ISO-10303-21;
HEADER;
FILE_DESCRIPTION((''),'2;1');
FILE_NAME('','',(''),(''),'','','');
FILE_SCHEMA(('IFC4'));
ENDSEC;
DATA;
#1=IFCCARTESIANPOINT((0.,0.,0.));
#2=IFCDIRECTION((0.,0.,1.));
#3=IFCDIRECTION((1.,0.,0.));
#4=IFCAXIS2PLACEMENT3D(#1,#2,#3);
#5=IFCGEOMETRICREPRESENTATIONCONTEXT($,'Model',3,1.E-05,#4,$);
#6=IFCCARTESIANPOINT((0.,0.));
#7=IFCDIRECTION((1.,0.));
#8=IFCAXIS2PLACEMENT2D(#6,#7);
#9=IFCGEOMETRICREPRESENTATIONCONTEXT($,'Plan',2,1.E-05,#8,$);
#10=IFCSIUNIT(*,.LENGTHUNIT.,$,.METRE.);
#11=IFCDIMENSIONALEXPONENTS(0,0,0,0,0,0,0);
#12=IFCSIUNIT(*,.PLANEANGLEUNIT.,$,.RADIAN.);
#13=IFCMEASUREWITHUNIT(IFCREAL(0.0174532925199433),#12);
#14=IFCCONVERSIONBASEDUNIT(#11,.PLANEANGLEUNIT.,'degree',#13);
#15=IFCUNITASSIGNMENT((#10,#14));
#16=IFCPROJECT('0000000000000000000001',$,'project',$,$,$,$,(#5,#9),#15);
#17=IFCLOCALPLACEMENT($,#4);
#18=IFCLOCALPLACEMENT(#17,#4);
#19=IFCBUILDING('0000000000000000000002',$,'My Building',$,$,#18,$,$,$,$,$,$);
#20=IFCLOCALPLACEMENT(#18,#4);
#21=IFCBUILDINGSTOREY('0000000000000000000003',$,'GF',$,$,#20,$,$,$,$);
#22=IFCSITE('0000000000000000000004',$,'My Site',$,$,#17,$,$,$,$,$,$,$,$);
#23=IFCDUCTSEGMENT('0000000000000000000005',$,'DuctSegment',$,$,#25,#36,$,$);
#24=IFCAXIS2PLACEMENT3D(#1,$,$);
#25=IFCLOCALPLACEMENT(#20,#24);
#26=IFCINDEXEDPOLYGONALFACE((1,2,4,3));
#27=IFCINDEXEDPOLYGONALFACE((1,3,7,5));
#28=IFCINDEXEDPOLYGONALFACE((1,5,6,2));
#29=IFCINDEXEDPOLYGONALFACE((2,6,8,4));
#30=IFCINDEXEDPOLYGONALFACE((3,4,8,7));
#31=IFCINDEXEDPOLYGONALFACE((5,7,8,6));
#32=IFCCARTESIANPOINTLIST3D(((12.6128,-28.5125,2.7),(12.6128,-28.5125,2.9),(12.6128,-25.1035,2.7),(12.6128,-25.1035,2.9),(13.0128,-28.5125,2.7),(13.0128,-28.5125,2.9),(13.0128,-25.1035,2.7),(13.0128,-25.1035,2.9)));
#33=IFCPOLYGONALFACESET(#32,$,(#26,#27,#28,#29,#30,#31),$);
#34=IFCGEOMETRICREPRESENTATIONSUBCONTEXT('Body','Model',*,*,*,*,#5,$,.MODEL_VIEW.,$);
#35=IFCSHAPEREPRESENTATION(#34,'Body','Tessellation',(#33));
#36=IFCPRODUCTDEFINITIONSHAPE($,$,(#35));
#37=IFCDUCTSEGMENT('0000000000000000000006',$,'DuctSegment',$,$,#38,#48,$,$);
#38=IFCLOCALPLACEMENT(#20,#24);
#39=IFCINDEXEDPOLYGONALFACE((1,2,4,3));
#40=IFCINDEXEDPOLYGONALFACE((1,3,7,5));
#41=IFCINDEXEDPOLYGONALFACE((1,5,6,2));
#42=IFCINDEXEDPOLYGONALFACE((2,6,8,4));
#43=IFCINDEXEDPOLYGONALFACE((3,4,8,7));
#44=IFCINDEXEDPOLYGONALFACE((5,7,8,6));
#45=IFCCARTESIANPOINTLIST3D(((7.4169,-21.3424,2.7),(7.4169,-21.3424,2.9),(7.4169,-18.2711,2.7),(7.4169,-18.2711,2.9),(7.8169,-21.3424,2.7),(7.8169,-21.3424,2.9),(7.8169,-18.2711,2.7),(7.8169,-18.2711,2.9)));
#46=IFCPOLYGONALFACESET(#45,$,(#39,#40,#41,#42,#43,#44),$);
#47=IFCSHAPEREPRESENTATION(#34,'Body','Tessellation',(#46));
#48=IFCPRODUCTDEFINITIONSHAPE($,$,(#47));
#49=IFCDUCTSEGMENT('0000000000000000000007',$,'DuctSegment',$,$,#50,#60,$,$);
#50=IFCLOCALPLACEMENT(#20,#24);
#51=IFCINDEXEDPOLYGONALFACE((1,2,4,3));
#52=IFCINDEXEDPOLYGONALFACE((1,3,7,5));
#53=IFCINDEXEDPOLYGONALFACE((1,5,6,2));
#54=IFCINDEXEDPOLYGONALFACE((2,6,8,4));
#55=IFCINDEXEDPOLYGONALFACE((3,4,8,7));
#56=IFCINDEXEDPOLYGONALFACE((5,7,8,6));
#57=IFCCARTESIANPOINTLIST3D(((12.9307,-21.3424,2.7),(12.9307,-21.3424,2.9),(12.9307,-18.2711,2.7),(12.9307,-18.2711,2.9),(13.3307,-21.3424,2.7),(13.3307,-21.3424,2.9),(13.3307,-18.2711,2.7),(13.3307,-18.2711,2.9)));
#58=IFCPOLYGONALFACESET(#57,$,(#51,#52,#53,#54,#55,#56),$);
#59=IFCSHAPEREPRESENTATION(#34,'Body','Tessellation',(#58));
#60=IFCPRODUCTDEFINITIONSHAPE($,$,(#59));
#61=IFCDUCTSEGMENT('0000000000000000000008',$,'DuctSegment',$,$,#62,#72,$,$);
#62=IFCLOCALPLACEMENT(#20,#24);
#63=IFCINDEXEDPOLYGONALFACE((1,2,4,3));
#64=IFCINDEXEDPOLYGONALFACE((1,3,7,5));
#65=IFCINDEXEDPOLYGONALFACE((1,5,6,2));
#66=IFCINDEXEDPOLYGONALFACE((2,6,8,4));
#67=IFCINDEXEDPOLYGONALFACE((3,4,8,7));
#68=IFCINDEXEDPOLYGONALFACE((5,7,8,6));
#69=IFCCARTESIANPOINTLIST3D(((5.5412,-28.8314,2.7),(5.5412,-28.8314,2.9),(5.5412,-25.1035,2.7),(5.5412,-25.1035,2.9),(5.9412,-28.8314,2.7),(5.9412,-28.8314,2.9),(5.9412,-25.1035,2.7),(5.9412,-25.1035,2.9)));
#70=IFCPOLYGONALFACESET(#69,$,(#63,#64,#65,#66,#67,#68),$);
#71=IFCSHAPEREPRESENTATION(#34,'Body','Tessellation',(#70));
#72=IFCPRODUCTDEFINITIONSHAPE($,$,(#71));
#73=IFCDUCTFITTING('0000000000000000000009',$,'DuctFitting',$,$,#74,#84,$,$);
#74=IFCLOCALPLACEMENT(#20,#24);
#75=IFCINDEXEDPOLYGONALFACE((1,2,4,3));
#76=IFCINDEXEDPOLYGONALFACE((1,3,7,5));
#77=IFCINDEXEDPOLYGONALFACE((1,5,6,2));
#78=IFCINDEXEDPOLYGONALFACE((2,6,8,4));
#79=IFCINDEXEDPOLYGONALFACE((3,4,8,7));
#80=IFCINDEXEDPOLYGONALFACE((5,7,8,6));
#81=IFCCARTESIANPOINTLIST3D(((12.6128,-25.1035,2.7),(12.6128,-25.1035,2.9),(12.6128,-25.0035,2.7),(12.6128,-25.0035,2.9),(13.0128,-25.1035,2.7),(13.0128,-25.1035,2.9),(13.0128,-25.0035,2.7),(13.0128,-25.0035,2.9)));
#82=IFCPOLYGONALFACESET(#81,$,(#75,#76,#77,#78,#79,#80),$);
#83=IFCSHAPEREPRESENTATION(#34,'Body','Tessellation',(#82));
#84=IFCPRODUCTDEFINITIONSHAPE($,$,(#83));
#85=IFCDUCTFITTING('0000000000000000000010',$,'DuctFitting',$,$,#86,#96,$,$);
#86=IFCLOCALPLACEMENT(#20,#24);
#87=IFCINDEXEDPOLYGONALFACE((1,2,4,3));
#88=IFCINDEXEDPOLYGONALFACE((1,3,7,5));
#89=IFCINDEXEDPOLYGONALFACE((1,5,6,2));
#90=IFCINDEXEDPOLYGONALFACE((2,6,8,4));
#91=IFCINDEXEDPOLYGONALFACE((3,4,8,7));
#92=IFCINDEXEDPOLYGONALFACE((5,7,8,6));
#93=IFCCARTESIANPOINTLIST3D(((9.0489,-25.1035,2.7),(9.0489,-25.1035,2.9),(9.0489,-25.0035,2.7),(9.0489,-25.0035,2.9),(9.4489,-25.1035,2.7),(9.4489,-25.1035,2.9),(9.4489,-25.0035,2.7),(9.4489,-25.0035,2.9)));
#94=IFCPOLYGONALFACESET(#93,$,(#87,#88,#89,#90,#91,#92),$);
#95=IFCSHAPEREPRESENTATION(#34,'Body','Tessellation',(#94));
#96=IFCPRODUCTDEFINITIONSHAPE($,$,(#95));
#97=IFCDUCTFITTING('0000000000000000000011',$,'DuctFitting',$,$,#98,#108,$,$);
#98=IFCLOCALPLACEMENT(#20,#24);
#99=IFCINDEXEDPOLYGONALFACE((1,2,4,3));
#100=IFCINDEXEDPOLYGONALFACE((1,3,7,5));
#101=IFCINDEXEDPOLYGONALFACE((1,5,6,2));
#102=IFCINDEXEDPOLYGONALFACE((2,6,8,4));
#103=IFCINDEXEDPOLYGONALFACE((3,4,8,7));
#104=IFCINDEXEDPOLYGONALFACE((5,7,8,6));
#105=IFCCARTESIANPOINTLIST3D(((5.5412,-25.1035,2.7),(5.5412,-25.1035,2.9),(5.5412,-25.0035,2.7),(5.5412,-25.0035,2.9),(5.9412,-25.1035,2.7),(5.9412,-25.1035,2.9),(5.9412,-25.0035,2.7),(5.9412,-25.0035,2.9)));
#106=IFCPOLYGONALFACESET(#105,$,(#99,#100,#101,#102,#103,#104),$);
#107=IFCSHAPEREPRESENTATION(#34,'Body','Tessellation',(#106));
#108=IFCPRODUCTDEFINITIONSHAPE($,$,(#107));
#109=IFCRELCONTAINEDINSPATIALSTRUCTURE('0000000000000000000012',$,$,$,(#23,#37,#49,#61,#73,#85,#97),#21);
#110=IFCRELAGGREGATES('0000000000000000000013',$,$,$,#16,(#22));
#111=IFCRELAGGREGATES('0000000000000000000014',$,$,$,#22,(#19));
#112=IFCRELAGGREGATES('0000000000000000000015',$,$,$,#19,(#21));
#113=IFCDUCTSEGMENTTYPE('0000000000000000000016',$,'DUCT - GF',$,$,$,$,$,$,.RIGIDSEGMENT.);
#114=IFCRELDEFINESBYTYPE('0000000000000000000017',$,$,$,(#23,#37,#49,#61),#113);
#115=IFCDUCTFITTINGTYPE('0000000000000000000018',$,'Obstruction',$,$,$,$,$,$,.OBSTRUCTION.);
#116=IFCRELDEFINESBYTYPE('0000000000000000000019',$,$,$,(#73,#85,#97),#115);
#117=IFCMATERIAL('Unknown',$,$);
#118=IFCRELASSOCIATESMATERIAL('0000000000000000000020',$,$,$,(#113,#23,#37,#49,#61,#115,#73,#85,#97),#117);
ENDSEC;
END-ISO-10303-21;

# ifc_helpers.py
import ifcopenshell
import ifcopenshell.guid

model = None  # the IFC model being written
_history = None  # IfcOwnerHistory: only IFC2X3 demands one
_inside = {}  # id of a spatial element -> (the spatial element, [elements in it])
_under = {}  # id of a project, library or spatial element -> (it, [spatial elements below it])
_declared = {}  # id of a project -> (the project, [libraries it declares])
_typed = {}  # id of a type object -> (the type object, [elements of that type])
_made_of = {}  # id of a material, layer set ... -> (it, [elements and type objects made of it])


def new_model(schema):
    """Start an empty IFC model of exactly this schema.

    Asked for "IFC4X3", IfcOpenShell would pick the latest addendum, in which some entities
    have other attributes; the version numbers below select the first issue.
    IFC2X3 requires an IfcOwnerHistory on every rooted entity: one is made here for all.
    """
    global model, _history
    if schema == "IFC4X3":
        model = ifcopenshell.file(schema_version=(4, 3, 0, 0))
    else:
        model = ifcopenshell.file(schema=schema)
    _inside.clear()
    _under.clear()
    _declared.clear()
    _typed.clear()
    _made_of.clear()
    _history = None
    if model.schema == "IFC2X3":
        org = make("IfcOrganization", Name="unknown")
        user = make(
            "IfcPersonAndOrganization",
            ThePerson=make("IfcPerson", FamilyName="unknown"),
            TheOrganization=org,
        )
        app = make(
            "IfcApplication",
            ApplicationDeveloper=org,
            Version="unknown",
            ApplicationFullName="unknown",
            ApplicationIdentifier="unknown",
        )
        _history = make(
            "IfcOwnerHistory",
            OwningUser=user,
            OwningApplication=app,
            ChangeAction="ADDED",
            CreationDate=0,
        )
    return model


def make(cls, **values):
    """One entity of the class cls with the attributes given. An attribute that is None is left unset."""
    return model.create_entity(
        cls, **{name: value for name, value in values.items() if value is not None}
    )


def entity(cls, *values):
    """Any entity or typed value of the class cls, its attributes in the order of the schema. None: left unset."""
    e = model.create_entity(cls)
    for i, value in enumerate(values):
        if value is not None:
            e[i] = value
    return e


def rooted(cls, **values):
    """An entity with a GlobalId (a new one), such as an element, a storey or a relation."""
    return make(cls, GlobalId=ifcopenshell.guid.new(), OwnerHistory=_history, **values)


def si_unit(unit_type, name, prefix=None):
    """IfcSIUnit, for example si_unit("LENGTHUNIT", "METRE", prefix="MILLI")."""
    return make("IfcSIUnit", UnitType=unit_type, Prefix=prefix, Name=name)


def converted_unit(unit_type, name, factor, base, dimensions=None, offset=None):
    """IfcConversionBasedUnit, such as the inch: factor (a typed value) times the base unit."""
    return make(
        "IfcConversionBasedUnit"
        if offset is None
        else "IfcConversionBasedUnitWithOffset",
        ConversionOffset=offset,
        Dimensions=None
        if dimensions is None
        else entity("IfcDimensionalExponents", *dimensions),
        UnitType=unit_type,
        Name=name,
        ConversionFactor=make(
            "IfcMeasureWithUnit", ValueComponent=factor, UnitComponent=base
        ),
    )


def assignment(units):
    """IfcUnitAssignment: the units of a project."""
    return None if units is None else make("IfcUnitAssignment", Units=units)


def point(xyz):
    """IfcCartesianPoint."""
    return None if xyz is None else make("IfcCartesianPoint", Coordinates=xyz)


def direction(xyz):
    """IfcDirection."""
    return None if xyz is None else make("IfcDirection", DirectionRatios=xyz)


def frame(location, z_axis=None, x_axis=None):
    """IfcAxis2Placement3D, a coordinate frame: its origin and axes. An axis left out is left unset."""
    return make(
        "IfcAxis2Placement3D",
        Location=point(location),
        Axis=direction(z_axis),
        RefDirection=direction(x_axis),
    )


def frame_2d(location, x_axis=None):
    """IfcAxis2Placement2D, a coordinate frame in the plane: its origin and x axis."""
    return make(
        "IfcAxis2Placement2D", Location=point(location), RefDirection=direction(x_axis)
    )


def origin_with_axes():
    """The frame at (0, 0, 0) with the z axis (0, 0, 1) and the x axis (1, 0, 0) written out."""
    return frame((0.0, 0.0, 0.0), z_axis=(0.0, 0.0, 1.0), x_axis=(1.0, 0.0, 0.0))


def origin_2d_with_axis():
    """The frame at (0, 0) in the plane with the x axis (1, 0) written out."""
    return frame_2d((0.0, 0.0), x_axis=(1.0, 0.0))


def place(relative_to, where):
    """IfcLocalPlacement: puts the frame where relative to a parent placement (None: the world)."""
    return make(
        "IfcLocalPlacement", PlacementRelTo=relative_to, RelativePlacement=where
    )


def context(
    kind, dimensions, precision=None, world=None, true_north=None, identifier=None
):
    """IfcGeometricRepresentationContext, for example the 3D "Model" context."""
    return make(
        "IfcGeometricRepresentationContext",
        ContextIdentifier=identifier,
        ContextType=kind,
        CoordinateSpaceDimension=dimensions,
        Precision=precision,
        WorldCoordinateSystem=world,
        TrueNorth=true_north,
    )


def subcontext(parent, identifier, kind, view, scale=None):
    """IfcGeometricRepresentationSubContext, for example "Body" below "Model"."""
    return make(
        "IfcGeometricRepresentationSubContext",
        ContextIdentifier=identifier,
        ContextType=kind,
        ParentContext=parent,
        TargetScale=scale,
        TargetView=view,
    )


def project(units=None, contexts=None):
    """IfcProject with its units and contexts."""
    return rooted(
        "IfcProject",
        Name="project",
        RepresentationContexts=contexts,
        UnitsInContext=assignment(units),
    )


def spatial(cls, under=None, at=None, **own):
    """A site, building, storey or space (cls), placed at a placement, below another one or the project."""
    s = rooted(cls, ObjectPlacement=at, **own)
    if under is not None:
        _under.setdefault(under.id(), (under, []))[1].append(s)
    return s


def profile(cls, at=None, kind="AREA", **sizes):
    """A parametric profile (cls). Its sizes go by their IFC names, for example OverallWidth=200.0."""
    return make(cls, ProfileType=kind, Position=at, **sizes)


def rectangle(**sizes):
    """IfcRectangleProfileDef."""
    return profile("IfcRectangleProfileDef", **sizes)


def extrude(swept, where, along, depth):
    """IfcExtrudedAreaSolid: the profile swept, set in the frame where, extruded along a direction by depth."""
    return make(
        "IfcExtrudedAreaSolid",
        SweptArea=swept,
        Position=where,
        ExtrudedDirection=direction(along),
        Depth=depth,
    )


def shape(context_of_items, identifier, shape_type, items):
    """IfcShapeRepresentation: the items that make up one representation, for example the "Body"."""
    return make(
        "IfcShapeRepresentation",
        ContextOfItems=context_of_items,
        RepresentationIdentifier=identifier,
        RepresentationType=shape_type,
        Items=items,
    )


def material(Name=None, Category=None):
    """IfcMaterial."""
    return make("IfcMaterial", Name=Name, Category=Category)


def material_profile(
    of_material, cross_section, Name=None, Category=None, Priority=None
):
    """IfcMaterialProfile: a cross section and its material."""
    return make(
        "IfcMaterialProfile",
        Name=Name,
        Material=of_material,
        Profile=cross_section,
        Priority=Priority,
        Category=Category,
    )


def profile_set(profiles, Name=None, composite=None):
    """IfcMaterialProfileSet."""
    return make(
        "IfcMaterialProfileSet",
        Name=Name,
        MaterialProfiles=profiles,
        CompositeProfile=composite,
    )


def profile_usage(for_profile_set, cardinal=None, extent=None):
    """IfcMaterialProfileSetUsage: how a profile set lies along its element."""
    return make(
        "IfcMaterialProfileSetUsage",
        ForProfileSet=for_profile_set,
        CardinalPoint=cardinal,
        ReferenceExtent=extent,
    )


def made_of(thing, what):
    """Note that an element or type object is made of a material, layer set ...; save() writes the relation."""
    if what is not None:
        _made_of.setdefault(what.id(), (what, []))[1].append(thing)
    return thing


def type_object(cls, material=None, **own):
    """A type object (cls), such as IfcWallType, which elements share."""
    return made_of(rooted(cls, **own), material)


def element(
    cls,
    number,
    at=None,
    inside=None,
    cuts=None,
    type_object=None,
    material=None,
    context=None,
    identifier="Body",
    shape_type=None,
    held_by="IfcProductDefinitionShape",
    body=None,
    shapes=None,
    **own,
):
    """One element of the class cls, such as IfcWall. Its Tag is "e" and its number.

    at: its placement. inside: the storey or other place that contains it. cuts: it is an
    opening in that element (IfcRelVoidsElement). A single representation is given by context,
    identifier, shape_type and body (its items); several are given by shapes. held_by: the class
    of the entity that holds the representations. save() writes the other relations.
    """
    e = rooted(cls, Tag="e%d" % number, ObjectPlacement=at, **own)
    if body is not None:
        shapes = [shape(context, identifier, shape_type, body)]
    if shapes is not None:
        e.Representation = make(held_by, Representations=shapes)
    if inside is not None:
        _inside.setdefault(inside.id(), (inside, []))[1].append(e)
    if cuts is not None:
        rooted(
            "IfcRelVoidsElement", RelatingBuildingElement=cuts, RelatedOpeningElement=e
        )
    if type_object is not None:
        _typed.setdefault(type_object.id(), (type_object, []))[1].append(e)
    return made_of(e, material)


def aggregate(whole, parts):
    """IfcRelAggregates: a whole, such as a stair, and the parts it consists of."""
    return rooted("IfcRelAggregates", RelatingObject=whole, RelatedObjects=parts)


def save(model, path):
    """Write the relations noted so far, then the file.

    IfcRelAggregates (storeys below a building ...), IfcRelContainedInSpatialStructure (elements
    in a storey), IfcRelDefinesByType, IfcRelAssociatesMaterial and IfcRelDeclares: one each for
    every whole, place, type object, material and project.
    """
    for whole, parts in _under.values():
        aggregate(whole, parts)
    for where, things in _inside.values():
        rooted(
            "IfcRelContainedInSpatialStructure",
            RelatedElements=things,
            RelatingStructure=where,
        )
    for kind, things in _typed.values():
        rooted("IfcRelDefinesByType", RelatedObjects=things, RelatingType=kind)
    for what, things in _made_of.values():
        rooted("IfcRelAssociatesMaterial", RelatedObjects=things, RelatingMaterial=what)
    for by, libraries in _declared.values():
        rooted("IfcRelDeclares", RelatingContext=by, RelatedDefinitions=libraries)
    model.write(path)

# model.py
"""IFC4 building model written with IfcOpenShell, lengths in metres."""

from ifc_helpers import new_model, entity, si_unit, converted_unit, frame, origin_with_axes, origin_2d_with_axis, place, context, subcontext, project, spatial, rectangle, extrude, material, material_profile, profile_set, profile_usage, type_object, element, save


model = new_model("IFC4")

# Units and contexts
model_context = context("Model", 3, precision=1e-05, world=origin_with_axes())
plan_context = context("Plan", 2, precision=1e-05, world=origin_2d_with_axis())
body_context_1 = subcontext(model_context, "Body", "Model", "MODEL_VIEW")
ifc_project = project(units=[si_unit("LENGTHUNIT", "METRE"), converted_unit("PLANEANGLEUNIT", "degree", entity("IfcReal", 0.0174532925199433), si_unit("PLANEANGLEUNIT", "RADIAN"), dimensions=[0, 0, 0, 0, 0, 0, 0])], contexts=[model_context, plan_context])

# Site, building, storey
site_placement = place(None, origin_with_axes())
site = spatial("IfcSite", under=ifc_project, at=site_placement, Name="My Site")
building_placement = place(site_placement, origin_with_axes())
building = spatial("IfcBuilding", under=site, at=building_placement, Name="My Building")
storey_placement = place(building_placement, origin_with_axes())
storey = spatial("IfcBuildingStorey", under=building, at=storey_placement, Name="GF")

# Shared definitions
ifc_material = material(Name="Unknown")

# Duct segments
ifc_material_profile_1 = material_profile(ifc_material, rectangle(XDim=0.4, YDim=0.2))
ifc_profile_set_1 = profile_set([ifc_material_profile_1])
duct_segment_type = type_object("IfcDuctSegmentType", Name="DUCT - GF", PredefinedType="RIGIDSEGMENT", material=ifc_profile_set_1)
ifc_profile_usage_1 = profile_usage(ifc_profile_set_1, cardinal=5)
duct_segment_1_placement = place(storey_placement, frame((12.8128, -28.5125, 2.8), z_axis=(0.0, 1.0, 0.0), x_axis=(-1.0, 0.0, 0.0)))
element("IfcDuctSegment", 1, at=duct_segment_1_placement, inside=storey, type_object=duct_segment_type, material=ifc_profile_usage_1, Name="DuctSegment", context=body_context_1, shape_type="SweptSolid", body=[
    extrude(rectangle(XDim=0.4, YDim=0.2), origin_with_axes(), (0.0, 0.0, 1.0), 3.409),
])
ifc_profile_usage_2 = profile_usage(ifc_profile_set_1, cardinal=5)
duct_segment_2_placement = place(storey_placement, frame((7.6169, -21.3424, 2.8), z_axis=(0.0, 1.0, 0.0), x_axis=(-1.0, 0.0, 0.0)))
element("IfcDuctSegment", 2, at=duct_segment_2_placement, inside=storey, type_object=duct_segment_type, material=ifc_profile_usage_2, Name="DuctSegment", context=body_context_1, shape_type="SweptSolid", body=[
    extrude(rectangle(XDim=0.4, YDim=0.2), origin_with_axes(), (0.0, 0.0, 1.0), 3.0713),
])
ifc_profile_usage_3 = profile_usage(ifc_profile_set_1, cardinal=5)
duct_segment_3_placement = place(storey_placement, frame((13.1307, -21.3424, 2.8), z_axis=(0.0, 1.0, 0.0), x_axis=(-1.0, 0.0, 0.0)))
element("IfcDuctSegment", 3, at=duct_segment_3_placement, inside=storey, type_object=duct_segment_type, material=ifc_profile_usage_3, Name="DuctSegment", context=body_context_1, shape_type="SweptSolid", body=[
    extrude(rectangle(XDim=0.4, YDim=0.2), origin_with_axes(), (0.0, 0.0, 1.0), 3.0713),
])
ifc_profile_usage_4 = profile_usage(ifc_profile_set_1, cardinal=5)
duct_segment_4_placement = place(storey_placement, frame((5.7412, -28.8314, 2.8), z_axis=(0.0, 1.0, 0.0), x_axis=(-1.0, 0.0, 0.0)))
element("IfcDuctSegment", 4, at=duct_segment_4_placement, inside=storey, type_object=duct_segment_type, material=ifc_profile_usage_4, Name="DuctSegment", context=body_context_1, shape_type="SweptSolid", body=[
    extrude(rectangle(XDim=0.4, YDim=0.2), origin_with_axes(), (0.0, 0.0, 1.0), 3.7279),
])

# Duct fittings
ifc_material_profile_2 = material_profile(ifc_material, rectangle(XDim=0.4, YDim=0.2))
ifc_profile_set_2 = profile_set([ifc_material_profile_2])
ifc_profile_usage_5 = profile_usage(ifc_profile_set_2, cardinal=5)
duct_fitting_type = type_object("IfcDuctFittingType", Name="Obstruction", PredefinedType="OBSTRUCTION", material=ifc_profile_set_2)
duct_fitting_1_placement = place(storey_placement, frame((12.8128, -25.1035, 2.8), z_axis=(0.0, 1.0, 0.0), x_axis=(-1.0, 0.0, 0.0)))
element("IfcDuctFitting", 5, at=duct_fitting_1_placement, inside=storey, type_object=duct_fitting_type, material=ifc_profile_usage_5, Name="DuctFitting", context=body_context_1, shape_type="SweptSolid", body=[
    extrude(rectangle(XDim=0.4, YDim=0.2), origin_with_axes(), (0.0, 0.0, 1.0), 0.1),
])
ifc_profile_usage_6 = profile_usage(ifc_profile_set_2, cardinal=5)
duct_fitting_2_placement = place(storey_placement, frame((9.2489, -25.1035, 2.8), z_axis=(0.0, 1.0, 0.0), x_axis=(-1.0, 0.0, 0.0)))
element("IfcDuctFitting", 6, at=duct_fitting_2_placement, inside=storey, type_object=duct_fitting_type, material=ifc_profile_usage_6, Name="DuctFitting", context=body_context_1, shape_type="SweptSolid", body=[
    extrude(rectangle(XDim=0.4, YDim=0.2), origin_with_axes(), (0.0, 0.0, 1.0), 0.1),
])
ifc_profile_usage_7 = profile_usage(ifc_profile_set_2, cardinal=5)
duct_fitting_3_placement = place(storey_placement, frame((5.7412, -25.1035, 2.8), z_axis=(0.0, 1.0, 0.0), x_axis=(-1.0, 0.0, 0.0)))
element("IfcDuctFitting", 7, at=duct_fitting_3_placement, inside=storey, type_object=duct_fitting_type, material=ifc_profile_usage_7, Name="DuctFitting", context=body_context_1, shape_type="SweptSolid", body=[
    extrude(rectangle(XDim=0.4, YDim=0.2), origin_with_axes(), (0.0, 0.0, 1.0), 0.1),
])

save(model, "model.ifc")
